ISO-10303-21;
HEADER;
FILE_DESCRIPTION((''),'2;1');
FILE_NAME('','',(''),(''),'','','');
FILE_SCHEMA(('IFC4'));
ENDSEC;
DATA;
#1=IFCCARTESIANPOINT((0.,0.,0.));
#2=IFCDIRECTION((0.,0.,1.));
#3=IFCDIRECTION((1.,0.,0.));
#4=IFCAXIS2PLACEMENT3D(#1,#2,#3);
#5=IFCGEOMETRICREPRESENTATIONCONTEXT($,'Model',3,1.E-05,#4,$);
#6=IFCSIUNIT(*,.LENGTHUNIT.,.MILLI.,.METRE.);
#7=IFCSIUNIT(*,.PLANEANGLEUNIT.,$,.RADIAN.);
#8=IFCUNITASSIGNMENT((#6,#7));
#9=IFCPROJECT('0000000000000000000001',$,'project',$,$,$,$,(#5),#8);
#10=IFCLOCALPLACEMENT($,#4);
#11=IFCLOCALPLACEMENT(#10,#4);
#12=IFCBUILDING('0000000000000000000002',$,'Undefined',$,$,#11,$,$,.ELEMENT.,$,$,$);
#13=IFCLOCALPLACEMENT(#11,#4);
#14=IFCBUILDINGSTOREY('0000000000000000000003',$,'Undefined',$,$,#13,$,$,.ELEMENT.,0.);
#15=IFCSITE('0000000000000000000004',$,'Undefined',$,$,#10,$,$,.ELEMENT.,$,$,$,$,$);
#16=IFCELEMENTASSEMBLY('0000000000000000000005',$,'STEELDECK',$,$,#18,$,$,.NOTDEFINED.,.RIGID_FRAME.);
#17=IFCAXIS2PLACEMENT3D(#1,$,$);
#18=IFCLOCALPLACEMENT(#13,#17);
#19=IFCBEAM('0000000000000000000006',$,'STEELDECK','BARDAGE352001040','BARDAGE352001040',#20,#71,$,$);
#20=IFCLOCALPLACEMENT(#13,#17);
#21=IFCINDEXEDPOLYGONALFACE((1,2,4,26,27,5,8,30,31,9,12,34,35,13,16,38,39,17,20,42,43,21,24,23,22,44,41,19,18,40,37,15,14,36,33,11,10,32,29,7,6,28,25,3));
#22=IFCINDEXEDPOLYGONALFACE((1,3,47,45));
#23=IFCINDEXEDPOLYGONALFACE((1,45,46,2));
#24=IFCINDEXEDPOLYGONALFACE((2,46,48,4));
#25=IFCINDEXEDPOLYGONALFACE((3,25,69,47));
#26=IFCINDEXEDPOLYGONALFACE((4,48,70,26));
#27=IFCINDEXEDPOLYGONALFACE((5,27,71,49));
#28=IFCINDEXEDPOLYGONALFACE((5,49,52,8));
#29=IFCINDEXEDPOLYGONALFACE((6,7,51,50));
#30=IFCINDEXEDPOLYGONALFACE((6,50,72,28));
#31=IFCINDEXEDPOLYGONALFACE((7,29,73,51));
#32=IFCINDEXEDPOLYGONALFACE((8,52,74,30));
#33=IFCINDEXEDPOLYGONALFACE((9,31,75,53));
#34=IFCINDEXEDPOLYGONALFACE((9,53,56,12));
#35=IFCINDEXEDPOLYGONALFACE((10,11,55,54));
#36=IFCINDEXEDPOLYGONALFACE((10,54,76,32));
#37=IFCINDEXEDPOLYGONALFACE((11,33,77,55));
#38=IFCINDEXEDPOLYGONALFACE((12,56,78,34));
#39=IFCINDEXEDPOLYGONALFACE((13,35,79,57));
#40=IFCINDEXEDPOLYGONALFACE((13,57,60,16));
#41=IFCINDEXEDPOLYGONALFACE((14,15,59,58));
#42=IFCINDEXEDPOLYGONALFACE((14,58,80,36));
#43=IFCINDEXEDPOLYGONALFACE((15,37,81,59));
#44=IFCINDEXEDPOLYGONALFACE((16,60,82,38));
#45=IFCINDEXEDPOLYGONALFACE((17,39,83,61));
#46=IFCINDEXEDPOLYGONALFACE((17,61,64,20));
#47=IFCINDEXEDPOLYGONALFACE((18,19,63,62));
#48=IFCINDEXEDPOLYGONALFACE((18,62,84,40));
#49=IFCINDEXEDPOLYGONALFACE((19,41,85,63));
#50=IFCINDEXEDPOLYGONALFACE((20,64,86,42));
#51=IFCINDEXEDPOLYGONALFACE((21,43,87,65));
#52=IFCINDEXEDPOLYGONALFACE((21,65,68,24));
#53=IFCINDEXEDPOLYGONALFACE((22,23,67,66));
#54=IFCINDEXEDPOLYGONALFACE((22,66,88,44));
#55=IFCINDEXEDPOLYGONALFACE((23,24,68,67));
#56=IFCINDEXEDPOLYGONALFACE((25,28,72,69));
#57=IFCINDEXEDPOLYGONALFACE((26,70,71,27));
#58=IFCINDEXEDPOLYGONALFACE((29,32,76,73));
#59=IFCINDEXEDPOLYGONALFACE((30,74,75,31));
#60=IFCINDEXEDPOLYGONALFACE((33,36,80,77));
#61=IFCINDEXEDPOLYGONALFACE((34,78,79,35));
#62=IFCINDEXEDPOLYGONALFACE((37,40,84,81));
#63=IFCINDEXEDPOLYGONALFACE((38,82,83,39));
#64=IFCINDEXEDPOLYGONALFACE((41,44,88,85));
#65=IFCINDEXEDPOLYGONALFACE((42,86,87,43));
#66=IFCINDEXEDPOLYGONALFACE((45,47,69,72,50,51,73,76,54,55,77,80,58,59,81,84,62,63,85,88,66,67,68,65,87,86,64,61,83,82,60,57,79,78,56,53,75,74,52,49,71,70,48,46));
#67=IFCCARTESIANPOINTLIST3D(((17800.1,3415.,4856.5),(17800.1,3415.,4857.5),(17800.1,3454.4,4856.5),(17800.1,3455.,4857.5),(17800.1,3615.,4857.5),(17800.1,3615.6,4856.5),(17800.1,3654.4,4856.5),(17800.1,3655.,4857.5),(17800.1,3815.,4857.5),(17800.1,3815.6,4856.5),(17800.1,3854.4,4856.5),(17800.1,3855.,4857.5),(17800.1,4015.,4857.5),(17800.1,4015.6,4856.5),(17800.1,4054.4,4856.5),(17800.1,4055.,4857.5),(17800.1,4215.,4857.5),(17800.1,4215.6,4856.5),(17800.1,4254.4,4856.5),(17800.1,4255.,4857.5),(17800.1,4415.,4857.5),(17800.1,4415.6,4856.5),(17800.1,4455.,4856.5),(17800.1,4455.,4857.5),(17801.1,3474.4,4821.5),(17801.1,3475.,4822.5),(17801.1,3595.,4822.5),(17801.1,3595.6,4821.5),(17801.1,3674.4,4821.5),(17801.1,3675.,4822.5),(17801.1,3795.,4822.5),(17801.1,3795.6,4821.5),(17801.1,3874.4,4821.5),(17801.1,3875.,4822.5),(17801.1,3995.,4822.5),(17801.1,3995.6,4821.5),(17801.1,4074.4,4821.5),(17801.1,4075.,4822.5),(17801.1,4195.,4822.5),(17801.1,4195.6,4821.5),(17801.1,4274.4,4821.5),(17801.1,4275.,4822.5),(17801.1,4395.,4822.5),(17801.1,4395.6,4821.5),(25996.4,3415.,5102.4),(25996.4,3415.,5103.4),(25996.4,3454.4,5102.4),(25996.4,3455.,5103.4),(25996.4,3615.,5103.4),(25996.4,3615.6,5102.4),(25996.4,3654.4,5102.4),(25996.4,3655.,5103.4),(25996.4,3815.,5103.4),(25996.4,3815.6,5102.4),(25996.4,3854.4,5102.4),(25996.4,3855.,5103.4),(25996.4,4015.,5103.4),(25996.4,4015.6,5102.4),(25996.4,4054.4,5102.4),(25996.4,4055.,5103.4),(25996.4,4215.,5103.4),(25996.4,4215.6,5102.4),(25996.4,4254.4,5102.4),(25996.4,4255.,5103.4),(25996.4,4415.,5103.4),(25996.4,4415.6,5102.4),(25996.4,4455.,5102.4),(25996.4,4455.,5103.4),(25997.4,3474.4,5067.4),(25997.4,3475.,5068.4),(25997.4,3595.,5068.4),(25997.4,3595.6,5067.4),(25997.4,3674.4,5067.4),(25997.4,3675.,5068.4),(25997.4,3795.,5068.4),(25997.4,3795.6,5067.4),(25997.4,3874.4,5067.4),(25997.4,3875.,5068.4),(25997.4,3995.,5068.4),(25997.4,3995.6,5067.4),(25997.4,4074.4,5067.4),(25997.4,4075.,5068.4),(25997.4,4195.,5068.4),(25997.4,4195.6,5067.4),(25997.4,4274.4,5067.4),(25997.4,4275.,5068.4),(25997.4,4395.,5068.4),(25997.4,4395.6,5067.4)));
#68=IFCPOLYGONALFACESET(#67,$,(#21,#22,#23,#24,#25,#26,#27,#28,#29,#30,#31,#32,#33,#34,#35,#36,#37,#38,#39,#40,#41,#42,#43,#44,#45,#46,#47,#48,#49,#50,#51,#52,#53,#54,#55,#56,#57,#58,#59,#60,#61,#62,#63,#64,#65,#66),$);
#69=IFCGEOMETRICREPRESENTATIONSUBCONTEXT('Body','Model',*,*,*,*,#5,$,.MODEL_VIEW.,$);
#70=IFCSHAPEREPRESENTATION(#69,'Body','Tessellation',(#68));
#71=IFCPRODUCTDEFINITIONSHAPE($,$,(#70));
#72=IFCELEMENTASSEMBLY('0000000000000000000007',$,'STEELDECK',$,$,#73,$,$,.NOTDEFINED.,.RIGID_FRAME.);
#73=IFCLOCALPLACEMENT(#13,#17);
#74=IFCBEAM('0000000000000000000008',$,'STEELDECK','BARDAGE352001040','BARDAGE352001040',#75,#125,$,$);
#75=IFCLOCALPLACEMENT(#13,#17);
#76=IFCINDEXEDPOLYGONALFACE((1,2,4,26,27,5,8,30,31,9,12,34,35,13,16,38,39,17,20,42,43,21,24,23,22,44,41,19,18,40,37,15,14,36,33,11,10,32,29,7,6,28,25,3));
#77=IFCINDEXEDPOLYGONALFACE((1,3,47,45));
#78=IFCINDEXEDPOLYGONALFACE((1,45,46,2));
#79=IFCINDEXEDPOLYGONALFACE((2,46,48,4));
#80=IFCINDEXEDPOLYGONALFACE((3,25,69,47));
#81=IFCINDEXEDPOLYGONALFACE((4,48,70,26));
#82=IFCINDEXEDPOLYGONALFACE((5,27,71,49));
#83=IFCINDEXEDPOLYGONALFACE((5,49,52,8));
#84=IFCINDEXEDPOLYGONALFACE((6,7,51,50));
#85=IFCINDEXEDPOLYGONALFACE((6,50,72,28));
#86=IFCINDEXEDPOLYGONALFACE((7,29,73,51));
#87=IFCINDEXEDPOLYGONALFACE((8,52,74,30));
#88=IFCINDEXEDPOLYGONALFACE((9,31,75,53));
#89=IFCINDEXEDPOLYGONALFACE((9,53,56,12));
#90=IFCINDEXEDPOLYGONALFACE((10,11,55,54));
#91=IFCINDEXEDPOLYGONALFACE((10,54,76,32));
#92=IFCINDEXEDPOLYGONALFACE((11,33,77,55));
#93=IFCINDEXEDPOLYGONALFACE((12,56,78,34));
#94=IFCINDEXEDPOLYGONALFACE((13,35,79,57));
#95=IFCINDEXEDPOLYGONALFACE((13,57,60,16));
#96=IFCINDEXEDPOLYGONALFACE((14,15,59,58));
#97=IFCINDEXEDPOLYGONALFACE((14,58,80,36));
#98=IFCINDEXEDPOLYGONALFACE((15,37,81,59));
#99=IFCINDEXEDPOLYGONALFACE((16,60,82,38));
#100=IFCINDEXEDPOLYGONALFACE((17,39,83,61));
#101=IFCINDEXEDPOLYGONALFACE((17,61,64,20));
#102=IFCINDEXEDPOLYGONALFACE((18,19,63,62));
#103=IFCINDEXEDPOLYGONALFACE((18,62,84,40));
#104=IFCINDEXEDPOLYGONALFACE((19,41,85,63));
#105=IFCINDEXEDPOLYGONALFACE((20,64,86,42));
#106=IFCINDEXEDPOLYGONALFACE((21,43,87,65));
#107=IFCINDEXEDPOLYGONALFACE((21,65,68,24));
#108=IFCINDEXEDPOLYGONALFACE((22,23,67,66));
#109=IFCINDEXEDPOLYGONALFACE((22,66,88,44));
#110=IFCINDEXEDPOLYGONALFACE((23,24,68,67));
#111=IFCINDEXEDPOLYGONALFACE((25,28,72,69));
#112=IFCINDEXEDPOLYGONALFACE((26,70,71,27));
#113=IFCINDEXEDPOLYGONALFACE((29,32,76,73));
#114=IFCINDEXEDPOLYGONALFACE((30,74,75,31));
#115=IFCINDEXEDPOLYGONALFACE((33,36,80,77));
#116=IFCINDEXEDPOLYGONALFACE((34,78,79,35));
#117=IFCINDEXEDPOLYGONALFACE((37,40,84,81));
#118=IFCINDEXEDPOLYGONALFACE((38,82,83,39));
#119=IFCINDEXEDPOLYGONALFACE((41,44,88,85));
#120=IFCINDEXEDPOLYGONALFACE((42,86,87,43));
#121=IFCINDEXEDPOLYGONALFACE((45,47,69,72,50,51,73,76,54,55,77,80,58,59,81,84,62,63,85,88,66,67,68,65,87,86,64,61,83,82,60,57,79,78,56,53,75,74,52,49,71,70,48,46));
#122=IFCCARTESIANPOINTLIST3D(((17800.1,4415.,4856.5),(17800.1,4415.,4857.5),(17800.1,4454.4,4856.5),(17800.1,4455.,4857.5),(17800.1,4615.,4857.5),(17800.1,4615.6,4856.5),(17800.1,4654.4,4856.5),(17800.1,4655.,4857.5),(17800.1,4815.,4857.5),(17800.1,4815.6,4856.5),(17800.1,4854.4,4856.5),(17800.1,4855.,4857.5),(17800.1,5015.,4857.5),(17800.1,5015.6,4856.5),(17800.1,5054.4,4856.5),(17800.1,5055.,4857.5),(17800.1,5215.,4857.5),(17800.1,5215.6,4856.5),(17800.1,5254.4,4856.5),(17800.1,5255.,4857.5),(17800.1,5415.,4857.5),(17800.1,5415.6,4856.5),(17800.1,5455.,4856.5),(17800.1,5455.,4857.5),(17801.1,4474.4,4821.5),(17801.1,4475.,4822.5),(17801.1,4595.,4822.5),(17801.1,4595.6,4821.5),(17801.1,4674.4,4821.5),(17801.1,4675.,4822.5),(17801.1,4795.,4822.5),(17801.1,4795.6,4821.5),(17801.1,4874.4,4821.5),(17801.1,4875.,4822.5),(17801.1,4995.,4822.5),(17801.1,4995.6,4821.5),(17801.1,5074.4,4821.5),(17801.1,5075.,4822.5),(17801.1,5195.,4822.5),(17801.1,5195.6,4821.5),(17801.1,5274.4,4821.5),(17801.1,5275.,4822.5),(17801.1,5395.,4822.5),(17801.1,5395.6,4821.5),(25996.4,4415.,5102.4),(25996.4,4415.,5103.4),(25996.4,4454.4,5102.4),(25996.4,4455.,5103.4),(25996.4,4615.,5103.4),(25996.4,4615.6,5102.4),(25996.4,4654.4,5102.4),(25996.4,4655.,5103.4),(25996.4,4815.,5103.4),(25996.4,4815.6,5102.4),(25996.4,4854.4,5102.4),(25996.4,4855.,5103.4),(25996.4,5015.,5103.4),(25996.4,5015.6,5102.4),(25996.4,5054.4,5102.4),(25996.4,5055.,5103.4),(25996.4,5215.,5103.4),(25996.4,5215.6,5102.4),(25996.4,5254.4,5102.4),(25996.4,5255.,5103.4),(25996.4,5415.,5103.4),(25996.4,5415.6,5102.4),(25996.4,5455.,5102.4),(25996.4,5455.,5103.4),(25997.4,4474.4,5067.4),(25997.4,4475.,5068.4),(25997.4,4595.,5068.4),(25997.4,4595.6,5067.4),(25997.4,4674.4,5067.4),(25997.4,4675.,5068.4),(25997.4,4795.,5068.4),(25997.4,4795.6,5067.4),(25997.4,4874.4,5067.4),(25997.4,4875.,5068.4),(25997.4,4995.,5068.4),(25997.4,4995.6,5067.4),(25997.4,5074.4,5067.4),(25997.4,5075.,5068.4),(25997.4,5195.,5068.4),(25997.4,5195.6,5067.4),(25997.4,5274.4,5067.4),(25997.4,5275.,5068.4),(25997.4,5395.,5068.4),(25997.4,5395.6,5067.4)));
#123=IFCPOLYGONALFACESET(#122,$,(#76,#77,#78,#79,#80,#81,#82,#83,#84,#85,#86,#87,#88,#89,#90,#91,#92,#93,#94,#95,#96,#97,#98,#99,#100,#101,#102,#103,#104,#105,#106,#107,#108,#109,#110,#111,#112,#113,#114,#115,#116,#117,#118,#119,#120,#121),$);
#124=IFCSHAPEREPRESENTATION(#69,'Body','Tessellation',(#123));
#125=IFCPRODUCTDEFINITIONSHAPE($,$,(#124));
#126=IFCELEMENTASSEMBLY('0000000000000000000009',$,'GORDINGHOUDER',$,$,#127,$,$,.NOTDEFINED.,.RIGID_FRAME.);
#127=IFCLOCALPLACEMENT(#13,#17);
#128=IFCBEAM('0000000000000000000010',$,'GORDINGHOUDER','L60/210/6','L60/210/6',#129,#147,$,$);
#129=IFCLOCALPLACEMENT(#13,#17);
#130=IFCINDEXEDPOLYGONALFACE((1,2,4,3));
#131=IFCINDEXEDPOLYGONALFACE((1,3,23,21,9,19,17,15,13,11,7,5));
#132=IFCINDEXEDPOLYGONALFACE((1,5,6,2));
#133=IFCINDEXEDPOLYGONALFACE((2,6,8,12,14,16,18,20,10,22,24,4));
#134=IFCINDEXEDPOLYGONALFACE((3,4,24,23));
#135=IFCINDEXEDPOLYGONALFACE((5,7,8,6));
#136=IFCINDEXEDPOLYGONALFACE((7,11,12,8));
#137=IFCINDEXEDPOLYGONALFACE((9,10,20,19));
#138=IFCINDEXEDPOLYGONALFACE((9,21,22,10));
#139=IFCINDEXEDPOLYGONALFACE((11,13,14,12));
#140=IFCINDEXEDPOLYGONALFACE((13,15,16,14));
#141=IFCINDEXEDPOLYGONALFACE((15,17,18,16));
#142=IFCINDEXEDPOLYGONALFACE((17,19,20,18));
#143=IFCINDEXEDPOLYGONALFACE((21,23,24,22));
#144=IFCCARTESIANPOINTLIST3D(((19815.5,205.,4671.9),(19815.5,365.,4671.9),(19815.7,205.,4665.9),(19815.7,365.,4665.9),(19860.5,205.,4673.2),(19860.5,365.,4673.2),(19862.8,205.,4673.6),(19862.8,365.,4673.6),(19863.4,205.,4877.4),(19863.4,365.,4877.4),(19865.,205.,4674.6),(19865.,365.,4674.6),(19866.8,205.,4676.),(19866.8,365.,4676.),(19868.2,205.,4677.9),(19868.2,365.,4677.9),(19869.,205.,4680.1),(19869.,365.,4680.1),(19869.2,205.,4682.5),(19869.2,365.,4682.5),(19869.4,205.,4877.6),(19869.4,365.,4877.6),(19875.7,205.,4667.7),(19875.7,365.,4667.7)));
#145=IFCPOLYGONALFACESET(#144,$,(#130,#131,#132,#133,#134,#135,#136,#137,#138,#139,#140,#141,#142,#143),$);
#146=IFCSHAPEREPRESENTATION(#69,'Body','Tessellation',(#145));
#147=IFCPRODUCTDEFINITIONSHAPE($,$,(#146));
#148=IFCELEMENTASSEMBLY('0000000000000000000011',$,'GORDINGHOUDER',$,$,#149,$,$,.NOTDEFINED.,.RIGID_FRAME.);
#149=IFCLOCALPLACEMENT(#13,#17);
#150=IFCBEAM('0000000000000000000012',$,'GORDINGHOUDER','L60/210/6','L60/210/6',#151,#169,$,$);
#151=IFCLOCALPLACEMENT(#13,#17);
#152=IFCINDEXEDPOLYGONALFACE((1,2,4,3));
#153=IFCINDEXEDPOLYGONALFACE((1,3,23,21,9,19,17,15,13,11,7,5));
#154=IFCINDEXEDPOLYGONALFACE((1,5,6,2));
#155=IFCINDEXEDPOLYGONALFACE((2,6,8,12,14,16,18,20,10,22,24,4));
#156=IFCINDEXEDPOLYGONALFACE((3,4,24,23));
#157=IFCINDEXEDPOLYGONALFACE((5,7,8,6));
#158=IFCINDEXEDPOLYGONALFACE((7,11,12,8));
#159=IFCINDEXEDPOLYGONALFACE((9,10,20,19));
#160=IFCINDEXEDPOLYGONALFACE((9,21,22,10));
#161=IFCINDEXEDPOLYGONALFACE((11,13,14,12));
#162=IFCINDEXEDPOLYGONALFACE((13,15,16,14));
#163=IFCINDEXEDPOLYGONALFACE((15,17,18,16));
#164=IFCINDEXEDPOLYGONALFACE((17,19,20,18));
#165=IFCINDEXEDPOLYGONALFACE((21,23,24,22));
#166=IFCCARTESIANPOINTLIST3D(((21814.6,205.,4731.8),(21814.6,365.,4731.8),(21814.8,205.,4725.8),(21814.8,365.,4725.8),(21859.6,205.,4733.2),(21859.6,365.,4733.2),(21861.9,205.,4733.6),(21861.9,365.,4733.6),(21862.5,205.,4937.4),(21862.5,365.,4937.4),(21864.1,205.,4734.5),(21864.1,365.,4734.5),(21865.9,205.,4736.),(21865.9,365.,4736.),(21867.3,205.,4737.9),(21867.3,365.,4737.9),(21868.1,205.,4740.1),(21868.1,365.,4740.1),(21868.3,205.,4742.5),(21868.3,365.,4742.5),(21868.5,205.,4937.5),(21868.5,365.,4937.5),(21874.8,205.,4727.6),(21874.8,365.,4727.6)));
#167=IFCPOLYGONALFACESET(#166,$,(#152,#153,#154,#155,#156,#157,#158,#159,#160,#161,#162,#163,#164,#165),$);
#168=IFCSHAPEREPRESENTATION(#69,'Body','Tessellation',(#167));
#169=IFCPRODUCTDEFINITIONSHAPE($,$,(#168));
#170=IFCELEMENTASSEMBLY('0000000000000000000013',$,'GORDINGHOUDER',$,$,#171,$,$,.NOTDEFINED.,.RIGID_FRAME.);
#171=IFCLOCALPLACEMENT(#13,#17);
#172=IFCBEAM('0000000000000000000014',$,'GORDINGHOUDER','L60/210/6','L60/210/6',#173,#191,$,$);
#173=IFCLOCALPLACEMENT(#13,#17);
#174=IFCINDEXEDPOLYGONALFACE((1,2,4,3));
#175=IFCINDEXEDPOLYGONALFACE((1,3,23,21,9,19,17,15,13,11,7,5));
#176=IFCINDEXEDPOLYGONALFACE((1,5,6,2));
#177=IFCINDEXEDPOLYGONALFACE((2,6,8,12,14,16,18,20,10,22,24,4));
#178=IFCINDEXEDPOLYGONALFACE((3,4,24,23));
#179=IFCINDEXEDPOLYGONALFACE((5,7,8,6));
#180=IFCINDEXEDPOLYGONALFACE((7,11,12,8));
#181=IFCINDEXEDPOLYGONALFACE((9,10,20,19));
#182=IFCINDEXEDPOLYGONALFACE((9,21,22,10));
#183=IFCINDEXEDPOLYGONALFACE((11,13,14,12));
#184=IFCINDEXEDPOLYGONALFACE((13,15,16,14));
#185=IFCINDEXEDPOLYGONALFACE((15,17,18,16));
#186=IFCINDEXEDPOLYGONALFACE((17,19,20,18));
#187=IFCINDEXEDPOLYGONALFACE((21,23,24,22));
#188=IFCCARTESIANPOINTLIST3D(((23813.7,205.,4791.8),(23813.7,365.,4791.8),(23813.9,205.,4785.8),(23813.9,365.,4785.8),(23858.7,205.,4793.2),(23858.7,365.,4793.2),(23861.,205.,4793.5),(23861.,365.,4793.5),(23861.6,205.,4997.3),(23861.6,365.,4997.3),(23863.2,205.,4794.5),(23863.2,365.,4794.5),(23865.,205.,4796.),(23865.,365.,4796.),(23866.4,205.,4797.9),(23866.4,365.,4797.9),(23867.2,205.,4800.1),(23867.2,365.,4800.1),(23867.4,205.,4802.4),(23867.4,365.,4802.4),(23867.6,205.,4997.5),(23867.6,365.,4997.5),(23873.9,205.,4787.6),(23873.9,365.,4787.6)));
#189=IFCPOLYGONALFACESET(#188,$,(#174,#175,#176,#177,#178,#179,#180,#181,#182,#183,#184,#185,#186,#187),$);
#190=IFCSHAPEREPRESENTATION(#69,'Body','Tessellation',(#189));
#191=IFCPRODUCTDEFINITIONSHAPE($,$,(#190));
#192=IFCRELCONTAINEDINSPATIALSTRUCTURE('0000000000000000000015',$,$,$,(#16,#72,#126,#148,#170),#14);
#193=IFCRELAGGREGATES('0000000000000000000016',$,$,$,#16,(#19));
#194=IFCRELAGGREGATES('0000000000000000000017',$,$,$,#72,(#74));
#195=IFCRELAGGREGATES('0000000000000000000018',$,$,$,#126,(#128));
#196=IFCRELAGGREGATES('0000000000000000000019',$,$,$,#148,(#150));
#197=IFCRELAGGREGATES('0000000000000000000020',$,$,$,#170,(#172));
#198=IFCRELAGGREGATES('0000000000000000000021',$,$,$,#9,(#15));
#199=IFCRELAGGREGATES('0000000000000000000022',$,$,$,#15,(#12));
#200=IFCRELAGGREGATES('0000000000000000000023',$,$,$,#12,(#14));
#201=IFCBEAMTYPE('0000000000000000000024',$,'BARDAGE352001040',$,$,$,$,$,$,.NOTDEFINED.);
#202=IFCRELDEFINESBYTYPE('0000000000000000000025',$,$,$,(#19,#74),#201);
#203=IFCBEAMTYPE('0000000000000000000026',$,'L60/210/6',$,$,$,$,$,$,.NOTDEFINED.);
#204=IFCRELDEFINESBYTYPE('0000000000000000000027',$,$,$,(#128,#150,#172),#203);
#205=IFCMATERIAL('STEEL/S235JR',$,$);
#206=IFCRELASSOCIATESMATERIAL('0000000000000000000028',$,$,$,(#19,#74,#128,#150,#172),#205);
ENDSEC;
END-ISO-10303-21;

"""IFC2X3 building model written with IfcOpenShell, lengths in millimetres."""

from ifc_helpers import new_model, si_unit, frame, frame_2d, origin_with_axes, place, context, subcontext, project, spatial, polyline, l_section, outline, extrude, material, type_object, element, aggregate, save


model = new_model("IFC2X3")

# Units and contexts
model_context = context("Model", 3, precision=1e-05, world=origin_with_axes())
body_context = subcontext(model_context, "Body", "Model", "MODEL_VIEW")
ifc_project = project(units=[si_unit("LENGTHUNIT", "METRE", prefix="MILLI"), si_unit("PLANEANGLEUNIT", "RADIAN")], contexts=[model_context])

# Site, building, storey
site_placement = place(None, origin_with_axes())
site = spatial("IfcSite", under=ifc_project, at=site_placement, Name="Undefined", CompositionType="ELEMENT")
building_placement = place(site_placement, origin_with_axes())
building = spatial("IfcBuilding", under=site, at=building_placement, Name="Undefined", CompositionType="ELEMENT")
storey_placement = place(building_placement, origin_with_axes())
storey = spatial("IfcBuildingStorey", under=building, at=storey_placement, Name="Undefined", CompositionType="ELEMENT", Elevation=0.0)

# Element assemblies, beams
ifc_material_1 = material(Name="STEEL/S235JR")
beam_type_1 = type_object("IfcBeamType", Name="BARDAGE352001040", PredefinedType="NOTDEFINED")
assembly_1_placement = place(storey_placement, origin_with_axes())
assembly_1 = element("IfcElementAssembly", 1, at=assembly_1_placement, inside=storey, Name="STEELDECK", AssemblyPlace="NOTDEFINED", PredefinedType="RIGID_FRAME")
beam_1_placement = place(assembly_1_placement, frame((17800.1, 4455.0, 4857.5), z_axis=(-0.029987, 0.0, 0.99955), x_axis=(0.99955, 0.0, 0.029986)))
beam_1 = element("IfcBeam", 2, at=beam_1_placement, type_object=beam_type_1, material=ifc_material_1, Name="STEELDECK", Description="BARDAGE352001040", ObjectType="BARDAGE352001040", context=body_context, shape_type="SweptSolid", body=[
    extrude(outline(polyline([(200.6, -1.0), (180.6, -36.0), (59.4, -36.0), (39.4, -1.0), (0.0, -1.0), (0.0, 0.0), (40.0, 0.0), (60.0, -35.0), (180.0, -35.0), (200.0, 0.0), (240.0, 0.0), (260.0, -35.0), (380.0, -35.0), (400.0, 0.0), (440.0, 0.0), (460.0, -35.0), (580.0, -35.0), (600.0, 0.0), (640.0, 0.0), (660.0, -35.0), (780.0, -35.0), (800.0, 0.0), (840.0, 0.0), (860.0, -35.0), (980.0, -35.0), (1000.0, 0.0), (1040.0, 0.0), (1040.0, -1.0), (1000.6, -1.0), (980.6, -36.0), (859.4, -36.0), (839.4, -1.0), (800.6, -1.0), (780.6, -36.0), (659.4, -36.0), (639.4, -1.0), (600.6, -1.0), (580.6, -36.0), (459.4, -36.0), (439.4, -1.0), (400.6, -1.0), (380.6, -36.0), (259.4, -36.0), (239.4, -1.0), (200.6, -1.0)])), frame((8200.0, 0.0, 0.0), z_axis=(-1.0, 0.0, 0.0), x_axis=(0.0, -1.0, 0.0)), (0.0, 0.0, 1.0), 8200.0),
])
aggregate(assembly_1, [beam_1])
assembly_2_placement = place(storey_placement, origin_with_axes())
assembly_2 = element("IfcElementAssembly", 3, at=assembly_2_placement, inside=storey, Name="STEELDECK", AssemblyPlace="NOTDEFINED", PredefinedType="RIGID_FRAME")
beam_2_placement = place(assembly_2_placement, frame((17800.1, 5455.0, 4857.5), z_axis=(-0.029987, 0.0, 0.99955), x_axis=(0.99955, 0.0, 0.029986)))
beam_2 = element("IfcBeam", 4, at=beam_2_placement, type_object=beam_type_1, material=ifc_material_1, Name="STEELDECK", Description="BARDAGE352001040", ObjectType="BARDAGE352001040", context=body_context, shape_type="SweptSolid", body=[
    extrude(outline(polyline([(200.6, -1.0), (180.6, -36.0), (59.4, -36.0), (39.4, -1.0), (0.0, -1.0), (0.0, 0.0), (40.0, 0.0), (60.0, -35.0), (180.0, -35.0), (200.0, 0.0), (240.0, 0.0), (260.0, -35.0), (380.0, -35.0), (400.0, 0.0), (440.0, 0.0), (460.0, -35.0), (580.0, -35.0), (600.0, 0.0), (640.0, 0.0), (660.0, -35.0), (780.0, -35.0), (800.0, 0.0), (840.0, 0.0), (860.0, -35.0), (980.0, -35.0), (1000.0, 0.0), (1040.0, 0.0), (1040.0, -1.0), (1000.6, -1.0), (980.6, -36.0), (859.4, -36.0), (839.4, -1.0), (800.6, -1.0), (780.6, -36.0), (659.4, -36.0), (639.4, -1.0), (600.6, -1.0), (580.6, -36.0), (459.4, -36.0), (439.4, -1.0), (400.6, -1.0), (380.6, -36.0), (259.4, -36.0), (239.4, -1.0), (200.6, -1.0)])), frame((8200.0, 0.0, 0.0), z_axis=(-1.0, 0.0, 0.0), x_axis=(0.0, -1.0, 0.0)), (0.0, 0.0, 1.0), 8200.0),
])
aggregate(assembly_2, [beam_2])
assembly_3_placement = place(storey_placement, origin_with_axes())
assembly_3 = element("IfcElementAssembly", 5, at=assembly_3_placement, inside=storey, Name="GORDINGHOUDER", AssemblyPlace="NOTDEFINED", PredefinedType="RIGID_FRAME")
beam_type_2 = type_object("IfcBeamType", Name="L60/210/6", PredefinedType="NOTDEFINED")
beam_3_placement = place(assembly_3_placement, frame((19842.5, 205.0, 4771.7), z_axis=(-0.99955, 0.0, -0.029987), x_axis=(0.0, 1.0, 0.0)))
beam_3 = element("IfcBeam", 6, at=beam_3_placement, type_object=beam_type_2, material=ifc_material_1, Name="GORDINGHOUDER", Description="L60/210/6", ObjectType="L60/210/6", context=body_context, shape_type="SweptSolid", body=[
    extrude(l_section(Depth=60.0, Width=210.0, Thickness=6.0, FilletRadius=9.0, at=frame_2d((0.0, 0.0), x_axis=(1.0, 0.0))), frame((160.0, 0.0, 0.0), z_axis=(-1.0, 0.0, 0.0), x_axis=(0.0, -1.0, 0.0)), (0.0, 0.0, 1.0), 160.0),
])
aggregate(assembly_3, [beam_3])
assembly_4_placement = place(storey_placement, origin_with_axes())
assembly_4 = element("IfcElementAssembly", 7, at=assembly_4_placement, inside=storey, Name="GORDINGHOUDER", AssemblyPlace="NOTDEFINED", PredefinedType="RIGID_FRAME")
beam_4_placement = place(assembly_4_placement, frame((21841.6, 205.0, 4831.7), z_axis=(-0.99955, 0.0, -0.029987), x_axis=(0.0, 1.0, 0.0)))
beam_4 = element("IfcBeam", 8, at=beam_4_placement, type_object=beam_type_2, material=ifc_material_1, Name="GORDINGHOUDER", Description="L60/210/6", ObjectType="L60/210/6", context=body_context, shape_type="SweptSolid", body=[
    extrude(l_section(Depth=60.0, Width=210.0, Thickness=6.0, FilletRadius=9.0, at=frame_2d((0.0, 0.0), x_axis=(1.0, 0.0))), frame((160.0, 0.0, 0.0), z_axis=(-1.0, 0.0, 0.0), x_axis=(0.0, -1.0, 0.0)), (0.0, 0.0, 1.0), 160.0),
])
aggregate(assembly_4, [beam_4])
assembly_5_placement = place(storey_placement, origin_with_axes())
assembly_5 = element("IfcElementAssembly", 9, at=assembly_5_placement, inside=storey, Name="GORDINGHOUDER", AssemblyPlace="NOTDEFINED", PredefinedType="RIGID_FRAME")
beam_5_placement = place(assembly_5_placement, frame((23840.7, 205.0, 4891.7), z_axis=(-0.99955, 0.0, -0.029987), x_axis=(0.0, 1.0, 0.0)))
beam_5 = element("IfcBeam", 10, at=beam_5_placement, type_object=beam_type_2, material=ifc_material_1, Name="GORDINGHOUDER", Description="L60/210/6", ObjectType="L60/210/6", context=body_context, shape_type="SweptSolid", body=[
    extrude(l_section(Depth=60.0, Width=210.0, Thickness=6.0, FilletRadius=9.0, at=frame_2d((0.0, 0.0), x_axis=(1.0, 0.0))), frame((160.0, 0.0, 0.0), z_axis=(-1.0, 0.0, 0.0), x_axis=(0.0, -1.0, 0.0)), (0.0, 0.0, 1.0), 160.0),
])
aggregate(assembly_5, [beam_5])

save(model, "model.ifc")
